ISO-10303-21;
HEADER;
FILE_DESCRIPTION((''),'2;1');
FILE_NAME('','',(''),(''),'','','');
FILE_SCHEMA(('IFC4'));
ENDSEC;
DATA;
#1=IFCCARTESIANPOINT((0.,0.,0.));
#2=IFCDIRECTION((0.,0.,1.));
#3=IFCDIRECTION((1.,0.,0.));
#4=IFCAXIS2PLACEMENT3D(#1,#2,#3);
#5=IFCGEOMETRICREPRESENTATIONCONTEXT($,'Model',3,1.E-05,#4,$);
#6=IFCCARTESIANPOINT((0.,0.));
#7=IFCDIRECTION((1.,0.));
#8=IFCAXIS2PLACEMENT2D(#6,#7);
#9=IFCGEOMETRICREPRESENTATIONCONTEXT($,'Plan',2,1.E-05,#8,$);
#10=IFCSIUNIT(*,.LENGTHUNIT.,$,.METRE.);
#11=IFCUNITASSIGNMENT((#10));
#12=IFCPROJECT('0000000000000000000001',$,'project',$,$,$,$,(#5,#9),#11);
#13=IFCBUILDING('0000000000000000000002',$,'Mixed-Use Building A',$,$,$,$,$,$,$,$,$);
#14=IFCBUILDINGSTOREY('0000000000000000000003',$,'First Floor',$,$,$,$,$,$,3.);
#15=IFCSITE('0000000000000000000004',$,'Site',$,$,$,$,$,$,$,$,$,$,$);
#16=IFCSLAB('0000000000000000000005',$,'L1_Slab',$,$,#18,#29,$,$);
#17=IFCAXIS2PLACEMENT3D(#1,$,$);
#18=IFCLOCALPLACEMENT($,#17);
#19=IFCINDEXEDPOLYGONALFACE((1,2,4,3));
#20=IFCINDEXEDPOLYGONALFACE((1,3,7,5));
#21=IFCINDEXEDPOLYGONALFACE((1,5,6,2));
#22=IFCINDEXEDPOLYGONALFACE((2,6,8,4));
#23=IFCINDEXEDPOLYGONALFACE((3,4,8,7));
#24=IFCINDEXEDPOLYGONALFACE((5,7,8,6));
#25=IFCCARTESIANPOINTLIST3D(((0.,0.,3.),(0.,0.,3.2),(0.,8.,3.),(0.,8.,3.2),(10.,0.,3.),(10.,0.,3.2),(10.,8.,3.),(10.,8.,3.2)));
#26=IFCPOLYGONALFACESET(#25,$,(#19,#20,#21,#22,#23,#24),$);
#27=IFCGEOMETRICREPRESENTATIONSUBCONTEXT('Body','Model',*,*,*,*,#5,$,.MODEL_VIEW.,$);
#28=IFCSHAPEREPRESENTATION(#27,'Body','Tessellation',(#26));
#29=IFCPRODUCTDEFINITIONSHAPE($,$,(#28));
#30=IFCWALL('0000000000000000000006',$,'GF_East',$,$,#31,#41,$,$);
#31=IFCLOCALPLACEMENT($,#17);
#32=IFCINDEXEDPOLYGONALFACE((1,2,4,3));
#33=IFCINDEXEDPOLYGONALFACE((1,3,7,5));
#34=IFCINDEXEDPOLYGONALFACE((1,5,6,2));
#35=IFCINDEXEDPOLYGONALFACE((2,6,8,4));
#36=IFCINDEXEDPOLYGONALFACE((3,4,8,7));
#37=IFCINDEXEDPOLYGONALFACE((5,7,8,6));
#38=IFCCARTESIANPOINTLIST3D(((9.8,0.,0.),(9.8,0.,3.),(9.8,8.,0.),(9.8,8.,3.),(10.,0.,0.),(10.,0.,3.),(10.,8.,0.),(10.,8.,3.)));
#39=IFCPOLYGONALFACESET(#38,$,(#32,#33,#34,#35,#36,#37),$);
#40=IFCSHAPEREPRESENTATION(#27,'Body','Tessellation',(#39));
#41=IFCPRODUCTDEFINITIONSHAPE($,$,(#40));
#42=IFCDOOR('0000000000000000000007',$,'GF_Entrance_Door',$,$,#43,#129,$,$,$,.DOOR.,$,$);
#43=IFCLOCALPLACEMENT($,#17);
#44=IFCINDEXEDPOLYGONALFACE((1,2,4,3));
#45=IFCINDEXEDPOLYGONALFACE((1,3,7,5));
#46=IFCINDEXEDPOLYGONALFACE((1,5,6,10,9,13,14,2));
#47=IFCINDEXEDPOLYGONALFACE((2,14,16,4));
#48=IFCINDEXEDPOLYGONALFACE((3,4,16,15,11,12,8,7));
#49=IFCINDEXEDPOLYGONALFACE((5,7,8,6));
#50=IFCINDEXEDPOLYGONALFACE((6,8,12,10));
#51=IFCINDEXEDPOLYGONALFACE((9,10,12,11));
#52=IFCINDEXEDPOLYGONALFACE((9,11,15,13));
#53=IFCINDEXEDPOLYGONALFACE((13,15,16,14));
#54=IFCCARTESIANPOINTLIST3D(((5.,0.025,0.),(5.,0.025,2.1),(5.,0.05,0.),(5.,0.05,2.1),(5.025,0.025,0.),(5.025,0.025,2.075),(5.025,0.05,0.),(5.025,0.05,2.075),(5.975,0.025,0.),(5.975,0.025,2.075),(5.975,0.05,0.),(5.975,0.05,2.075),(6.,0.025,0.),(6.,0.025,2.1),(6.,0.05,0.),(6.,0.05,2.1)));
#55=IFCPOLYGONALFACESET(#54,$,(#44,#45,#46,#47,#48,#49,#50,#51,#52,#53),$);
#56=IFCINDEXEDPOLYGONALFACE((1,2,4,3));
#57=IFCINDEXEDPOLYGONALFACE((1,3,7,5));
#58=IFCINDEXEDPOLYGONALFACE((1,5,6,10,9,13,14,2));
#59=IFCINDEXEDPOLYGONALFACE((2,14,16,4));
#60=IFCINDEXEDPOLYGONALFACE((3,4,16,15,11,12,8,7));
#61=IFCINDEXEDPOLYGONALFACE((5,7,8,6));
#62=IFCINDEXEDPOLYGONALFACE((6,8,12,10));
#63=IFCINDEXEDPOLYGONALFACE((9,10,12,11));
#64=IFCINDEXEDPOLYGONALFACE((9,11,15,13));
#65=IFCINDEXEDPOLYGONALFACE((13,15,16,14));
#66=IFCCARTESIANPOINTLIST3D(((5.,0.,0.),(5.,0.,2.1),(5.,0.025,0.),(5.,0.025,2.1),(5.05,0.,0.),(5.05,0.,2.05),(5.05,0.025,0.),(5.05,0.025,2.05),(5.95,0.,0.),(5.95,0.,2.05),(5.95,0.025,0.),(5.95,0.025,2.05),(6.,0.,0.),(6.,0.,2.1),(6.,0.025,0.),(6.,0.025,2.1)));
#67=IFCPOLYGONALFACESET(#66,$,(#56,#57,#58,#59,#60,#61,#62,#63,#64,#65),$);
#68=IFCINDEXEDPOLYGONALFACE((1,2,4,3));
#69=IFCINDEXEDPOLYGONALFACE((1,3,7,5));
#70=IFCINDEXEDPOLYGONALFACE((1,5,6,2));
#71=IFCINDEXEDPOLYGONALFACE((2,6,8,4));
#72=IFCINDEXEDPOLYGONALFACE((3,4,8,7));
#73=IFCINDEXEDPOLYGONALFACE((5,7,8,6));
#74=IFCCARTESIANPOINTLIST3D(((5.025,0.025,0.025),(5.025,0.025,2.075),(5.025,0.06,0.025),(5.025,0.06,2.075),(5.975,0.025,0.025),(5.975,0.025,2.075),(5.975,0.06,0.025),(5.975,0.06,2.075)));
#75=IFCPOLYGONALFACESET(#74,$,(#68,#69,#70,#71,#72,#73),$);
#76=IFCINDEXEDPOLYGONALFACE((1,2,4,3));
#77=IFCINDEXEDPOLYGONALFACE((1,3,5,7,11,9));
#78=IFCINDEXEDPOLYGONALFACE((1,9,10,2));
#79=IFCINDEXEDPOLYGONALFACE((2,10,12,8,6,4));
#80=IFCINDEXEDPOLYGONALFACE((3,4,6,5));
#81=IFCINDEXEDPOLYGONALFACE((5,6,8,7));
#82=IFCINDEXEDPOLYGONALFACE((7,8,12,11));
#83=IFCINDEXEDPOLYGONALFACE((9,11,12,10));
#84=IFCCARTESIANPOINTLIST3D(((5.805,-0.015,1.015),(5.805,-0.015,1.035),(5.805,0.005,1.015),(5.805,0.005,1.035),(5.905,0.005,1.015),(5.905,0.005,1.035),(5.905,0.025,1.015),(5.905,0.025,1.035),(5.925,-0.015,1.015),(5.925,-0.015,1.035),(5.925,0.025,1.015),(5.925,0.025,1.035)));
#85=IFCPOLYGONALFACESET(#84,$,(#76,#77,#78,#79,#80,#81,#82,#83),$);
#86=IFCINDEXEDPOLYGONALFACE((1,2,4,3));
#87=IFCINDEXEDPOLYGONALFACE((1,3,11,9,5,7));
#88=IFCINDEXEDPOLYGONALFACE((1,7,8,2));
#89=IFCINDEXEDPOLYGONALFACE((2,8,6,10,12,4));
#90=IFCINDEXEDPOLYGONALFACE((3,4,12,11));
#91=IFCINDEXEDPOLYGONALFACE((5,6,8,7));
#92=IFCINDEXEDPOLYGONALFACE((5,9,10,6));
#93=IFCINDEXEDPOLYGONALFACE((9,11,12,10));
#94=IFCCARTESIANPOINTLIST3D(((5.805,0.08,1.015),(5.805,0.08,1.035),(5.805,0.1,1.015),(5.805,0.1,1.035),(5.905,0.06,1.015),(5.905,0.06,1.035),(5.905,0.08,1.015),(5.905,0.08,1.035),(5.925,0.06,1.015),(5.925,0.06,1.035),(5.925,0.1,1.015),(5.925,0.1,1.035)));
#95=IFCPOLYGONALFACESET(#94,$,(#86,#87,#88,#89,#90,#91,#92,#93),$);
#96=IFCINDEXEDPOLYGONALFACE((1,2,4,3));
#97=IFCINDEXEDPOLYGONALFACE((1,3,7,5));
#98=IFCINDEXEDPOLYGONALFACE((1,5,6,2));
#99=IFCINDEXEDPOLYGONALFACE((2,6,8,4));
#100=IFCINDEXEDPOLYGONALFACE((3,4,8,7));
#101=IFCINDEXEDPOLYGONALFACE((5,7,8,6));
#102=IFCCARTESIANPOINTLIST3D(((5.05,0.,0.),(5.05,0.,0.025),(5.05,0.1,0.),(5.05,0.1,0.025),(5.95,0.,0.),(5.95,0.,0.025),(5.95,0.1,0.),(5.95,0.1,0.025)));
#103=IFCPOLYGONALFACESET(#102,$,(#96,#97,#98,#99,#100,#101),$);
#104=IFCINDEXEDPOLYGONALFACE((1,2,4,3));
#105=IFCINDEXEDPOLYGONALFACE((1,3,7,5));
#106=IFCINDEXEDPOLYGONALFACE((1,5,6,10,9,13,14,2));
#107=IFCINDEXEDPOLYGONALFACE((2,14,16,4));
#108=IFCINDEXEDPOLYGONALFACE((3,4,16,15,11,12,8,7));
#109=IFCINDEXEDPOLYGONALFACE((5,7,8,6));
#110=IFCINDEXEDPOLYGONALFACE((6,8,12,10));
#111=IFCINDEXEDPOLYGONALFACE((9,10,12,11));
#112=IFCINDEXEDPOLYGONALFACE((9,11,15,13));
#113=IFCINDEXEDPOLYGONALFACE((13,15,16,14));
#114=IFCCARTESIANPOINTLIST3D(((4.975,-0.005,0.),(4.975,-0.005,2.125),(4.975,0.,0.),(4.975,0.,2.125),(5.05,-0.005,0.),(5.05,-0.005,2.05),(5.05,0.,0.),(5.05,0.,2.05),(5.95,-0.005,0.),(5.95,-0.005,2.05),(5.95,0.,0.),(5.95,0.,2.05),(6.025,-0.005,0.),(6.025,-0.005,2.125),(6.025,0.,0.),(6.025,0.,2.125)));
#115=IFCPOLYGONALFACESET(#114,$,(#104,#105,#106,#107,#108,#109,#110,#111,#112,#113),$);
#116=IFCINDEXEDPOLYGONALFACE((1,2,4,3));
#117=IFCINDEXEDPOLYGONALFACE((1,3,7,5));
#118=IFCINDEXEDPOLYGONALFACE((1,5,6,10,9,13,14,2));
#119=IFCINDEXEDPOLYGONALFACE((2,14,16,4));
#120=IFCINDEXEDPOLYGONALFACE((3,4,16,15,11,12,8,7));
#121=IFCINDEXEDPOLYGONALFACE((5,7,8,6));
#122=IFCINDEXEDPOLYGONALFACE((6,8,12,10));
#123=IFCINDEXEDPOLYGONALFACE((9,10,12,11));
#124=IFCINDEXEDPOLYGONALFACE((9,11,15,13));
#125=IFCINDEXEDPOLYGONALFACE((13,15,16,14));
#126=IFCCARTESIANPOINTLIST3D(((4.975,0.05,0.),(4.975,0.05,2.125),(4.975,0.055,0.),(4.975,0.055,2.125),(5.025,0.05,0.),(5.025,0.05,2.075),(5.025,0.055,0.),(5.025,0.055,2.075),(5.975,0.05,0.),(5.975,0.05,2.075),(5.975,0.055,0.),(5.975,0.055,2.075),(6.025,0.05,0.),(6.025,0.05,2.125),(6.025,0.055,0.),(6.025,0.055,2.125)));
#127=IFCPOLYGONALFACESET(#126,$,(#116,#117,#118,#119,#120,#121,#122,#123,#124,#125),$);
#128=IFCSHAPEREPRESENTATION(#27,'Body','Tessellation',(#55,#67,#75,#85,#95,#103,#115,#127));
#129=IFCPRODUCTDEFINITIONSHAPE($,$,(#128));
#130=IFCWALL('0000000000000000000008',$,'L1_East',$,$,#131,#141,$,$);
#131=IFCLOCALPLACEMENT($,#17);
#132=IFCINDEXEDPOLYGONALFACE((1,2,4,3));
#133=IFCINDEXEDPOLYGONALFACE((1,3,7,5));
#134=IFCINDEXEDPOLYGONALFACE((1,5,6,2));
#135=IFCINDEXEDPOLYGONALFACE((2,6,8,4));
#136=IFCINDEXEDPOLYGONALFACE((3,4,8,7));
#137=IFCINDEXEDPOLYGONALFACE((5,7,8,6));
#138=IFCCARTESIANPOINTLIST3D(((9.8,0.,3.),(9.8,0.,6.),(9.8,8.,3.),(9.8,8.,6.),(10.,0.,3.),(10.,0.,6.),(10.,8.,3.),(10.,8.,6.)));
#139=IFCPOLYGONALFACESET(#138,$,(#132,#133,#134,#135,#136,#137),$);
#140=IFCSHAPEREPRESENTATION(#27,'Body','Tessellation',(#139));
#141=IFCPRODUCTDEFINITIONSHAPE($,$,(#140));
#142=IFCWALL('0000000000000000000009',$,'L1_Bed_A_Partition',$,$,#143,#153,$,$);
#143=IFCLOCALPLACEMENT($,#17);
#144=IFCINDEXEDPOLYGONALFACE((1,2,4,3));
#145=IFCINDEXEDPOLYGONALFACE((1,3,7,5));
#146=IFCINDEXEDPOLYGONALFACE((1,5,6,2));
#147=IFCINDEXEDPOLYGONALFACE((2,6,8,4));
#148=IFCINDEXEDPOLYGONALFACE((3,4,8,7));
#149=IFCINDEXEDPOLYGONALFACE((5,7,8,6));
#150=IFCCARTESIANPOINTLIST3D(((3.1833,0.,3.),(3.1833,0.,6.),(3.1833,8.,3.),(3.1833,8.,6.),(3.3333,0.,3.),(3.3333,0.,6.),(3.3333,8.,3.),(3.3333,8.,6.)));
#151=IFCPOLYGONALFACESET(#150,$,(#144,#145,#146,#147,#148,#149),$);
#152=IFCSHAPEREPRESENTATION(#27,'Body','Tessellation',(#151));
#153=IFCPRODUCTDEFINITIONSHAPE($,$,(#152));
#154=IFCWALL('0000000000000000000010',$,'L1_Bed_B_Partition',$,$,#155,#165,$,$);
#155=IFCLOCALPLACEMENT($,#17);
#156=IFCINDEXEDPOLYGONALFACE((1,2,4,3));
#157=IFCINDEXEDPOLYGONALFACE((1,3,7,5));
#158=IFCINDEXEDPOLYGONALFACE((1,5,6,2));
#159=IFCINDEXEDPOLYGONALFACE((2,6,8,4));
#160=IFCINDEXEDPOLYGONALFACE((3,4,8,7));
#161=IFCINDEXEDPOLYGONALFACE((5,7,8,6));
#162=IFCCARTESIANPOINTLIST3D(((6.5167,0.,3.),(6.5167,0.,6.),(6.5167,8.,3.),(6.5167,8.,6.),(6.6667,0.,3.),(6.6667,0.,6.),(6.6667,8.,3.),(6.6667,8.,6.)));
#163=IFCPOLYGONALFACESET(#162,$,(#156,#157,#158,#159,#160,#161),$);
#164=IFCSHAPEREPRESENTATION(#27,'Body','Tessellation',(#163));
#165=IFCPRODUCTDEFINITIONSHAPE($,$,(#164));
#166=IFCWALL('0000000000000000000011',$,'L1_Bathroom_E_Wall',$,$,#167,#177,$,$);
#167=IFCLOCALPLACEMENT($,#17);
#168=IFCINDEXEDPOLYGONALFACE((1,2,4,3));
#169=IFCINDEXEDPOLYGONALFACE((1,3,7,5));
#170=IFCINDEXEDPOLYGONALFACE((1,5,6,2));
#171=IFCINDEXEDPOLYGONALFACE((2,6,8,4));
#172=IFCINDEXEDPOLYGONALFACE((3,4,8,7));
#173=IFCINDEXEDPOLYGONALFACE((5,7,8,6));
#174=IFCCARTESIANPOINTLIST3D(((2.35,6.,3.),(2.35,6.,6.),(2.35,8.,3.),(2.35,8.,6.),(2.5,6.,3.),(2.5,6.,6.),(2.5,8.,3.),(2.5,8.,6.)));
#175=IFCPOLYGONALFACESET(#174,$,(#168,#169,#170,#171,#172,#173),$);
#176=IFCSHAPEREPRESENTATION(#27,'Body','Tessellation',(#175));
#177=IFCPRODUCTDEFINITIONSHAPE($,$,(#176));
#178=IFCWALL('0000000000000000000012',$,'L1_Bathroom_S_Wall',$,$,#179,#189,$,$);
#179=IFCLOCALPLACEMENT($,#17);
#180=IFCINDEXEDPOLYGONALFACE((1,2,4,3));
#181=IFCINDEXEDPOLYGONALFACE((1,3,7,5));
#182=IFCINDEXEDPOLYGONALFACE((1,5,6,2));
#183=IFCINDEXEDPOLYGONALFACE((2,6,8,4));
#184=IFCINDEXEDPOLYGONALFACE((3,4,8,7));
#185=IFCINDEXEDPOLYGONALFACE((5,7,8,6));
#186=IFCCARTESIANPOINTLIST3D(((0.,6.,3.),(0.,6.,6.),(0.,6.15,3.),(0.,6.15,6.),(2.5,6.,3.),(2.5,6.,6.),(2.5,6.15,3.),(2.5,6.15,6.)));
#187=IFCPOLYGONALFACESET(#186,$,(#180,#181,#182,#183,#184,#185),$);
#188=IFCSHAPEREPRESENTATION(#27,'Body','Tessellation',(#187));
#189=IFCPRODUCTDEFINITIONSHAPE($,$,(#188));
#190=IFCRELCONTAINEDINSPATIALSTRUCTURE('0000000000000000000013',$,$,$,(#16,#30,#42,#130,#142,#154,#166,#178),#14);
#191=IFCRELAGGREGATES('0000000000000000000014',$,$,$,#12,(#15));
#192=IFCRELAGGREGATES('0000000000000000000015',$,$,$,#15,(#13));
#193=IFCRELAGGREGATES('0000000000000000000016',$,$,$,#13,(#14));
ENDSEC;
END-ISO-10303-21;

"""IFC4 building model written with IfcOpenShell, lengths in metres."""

from ifc_helpers import new_model, si_unit, frame, origin_with_axes, origin_2d_with_axis, place, context, subcontext, project, spatial, line, indexed_curve, outline, extrude, element, save


model = new_model("IFC4")

# Units and contexts
model_context = context("Model", 3, precision=1e-05, world=origin_with_axes())
plan_context = context("Plan", 2, precision=1e-05, world=origin_2d_with_axis())
body_context = subcontext(model_context, "Body", "Model", "MODEL_VIEW")
ifc_project = project(units=[si_unit("LENGTHUNIT", "METRE")], contexts=[model_context, plan_context])

# Site, building, storey
site = spatial("IfcSite", under=ifc_project, Name="Site")
building = spatial("IfcBuilding", under=site, Name="Mixed-Use Building A")
storey = spatial("IfcBuildingStorey", under=building, Name="First Floor", Elevation=3.0)

# Slab
slab_placement = place(None, frame((0.0, 0.0, 3.0), z_axis=(0.0, 0.0, 1.0), x_axis=(1.0, 0.0, 0.0)))
element("IfcSlab", 1, at=slab_placement, inside=storey, Name="L1_Slab", context=body_context, shape_type="SweptSolid", body=[
    extrude(outline(indexed_curve([(0.0, 0.0), (10.0, 0.0), (10.0, 8.0), (0.0, 8.0)])), None, (0.0, 0.0, 1.0), 0.2),
])

# Wall
wall_1_placement = place(None, frame((10.0, 0.0, 0.0), z_axis=(0.0, 0.0, 1.0), x_axis=(0.0, 1.0, 0.0)))
element("IfcWall", 2, at=wall_1_placement, inside=storey, Name="GF_East", context=body_context, shape_type="SweptSolid", body=[
    extrude(outline(indexed_curve([(0.0, 0.0), (0.0, 0.2), (8.0, 0.2), (8.0, 0.0), (0.0, 0.0)], self_intersect=False)), origin_with_axes(), (0.0, 0.0, 1.0), 3.0),
])

# Door
door_placement = place(None, frame((5.0, 0.0, 0.0), z_axis=(0.0, 0.0, 1.0), x_axis=(1.0, 0.0, 0.0)))
element("IfcDoor", 3, at=door_placement, inside=storey, Name="GF_Entrance_Door", PredefinedType="DOOR", context=body_context, shape_type="SweptSolid", body=[
    extrude(outline(indexed_curve([(0.0, 0.0), (0.0, 2.1), (1.0, 2.1), (1.0, 0.0), (0.975, 0.0), (0.975, 2.075), (0.025, 2.075), (0.025, 0.0)], segments=[line(1, 2, 3, 4, 5, 6, 7, 8, 1)])), frame((0.0, 0.025, 0.0), z_axis=(0.0, -1.0, 0.0), x_axis=(1.0, 0.0, 0.0)), (0.0, 0.0, -1.0), 0.025),
    extrude(outline(indexed_curve([(0.0, 0.0), (0.0, 2.1), (1.0, 2.1), (1.0, 0.0), (0.95, 0.0), (0.95, 2.05), (0.05, 2.05), (0.05, 0.0)], segments=[line(1, 2, 3, 4, 5, 6, 7, 8, 1)])), frame((0.0, 0.0, 0.0), z_axis=(0.0, -1.0, 0.0), x_axis=(1.0, 0.0, 0.0)), (0.0, 0.0, -1.0), 0.025),
    extrude(outline(indexed_curve([(0.0, 0.0), (0.95, 0.0), (0.95, 0.035), (0.0, 0.035)], segments=[line(1, 2, 3, 4, 1)])), frame((0.025, 0.025, 0.025), z_axis=(0.0, 0.0, 1.0), x_axis=(1.0, 0.0, 0.0)), (0.0, 0.0, 1.0), 2.05),
    extrude(outline(indexed_curve([(0.0, 0.0), (0.0, -0.04), (-0.12, -0.04), (-0.12, -0.02), (-0.02, -0.02), (-0.02, 0.0)], segments=[line(1, 2, 3, 4, 5, 6, 1)])), frame((0.925, 0.025, 1.015), z_axis=(0.0, 0.0, 1.0), x_axis=(1.0, 0.0, 0.0)), (0.0, 0.0, 1.0), 0.02),
    extrude(outline(indexed_curve([(0.0, 0.0), (0.0, 0.04), (-0.12, 0.04), (-0.12, 0.02), (-0.02, 0.02), (-0.02, 0.0)], segments=[line(1, 2, 3, 4, 5, 6, 1)])), frame((0.925, 0.06, 1.015), z_axis=(0.0, 0.0, 1.0), x_axis=(1.0, 0.0, 0.0)), (0.0, 0.0, 1.0), 0.02),
    extrude(outline(indexed_curve([(0.0, 0.0), (0.9, 0.0), (0.9, 0.1), (0.0, 0.1)], segments=[line(1, 2, 3, 4, 1)])), frame((0.05, 0.0, 0.0), z_axis=(0.0, 0.0, 1.0), x_axis=(1.0, 0.0, 0.0)), (0.0, 0.0, 1.0), 0.025),
    extrude(outline(indexed_curve([(0.0, 0.0), (0.0, 2.125), (1.05, 2.125), (1.05, 0.0), (0.975, 0.0), (0.975, 2.05), (0.075, 2.05), (0.075, 0.0)], segments=[line(1, 2, 3, 4, 5, 6, 7, 8, 1)])), frame((-0.025, -0.005, 0.0), z_axis=(0.0, -1.0, 0.0), x_axis=(1.0, 0.0, 0.0)), (0.0, 0.0, -1.0), 0.005),
    extrude(outline(indexed_curve([(0.0, 0.0), (0.0, 2.125), (1.05, 2.125), (1.05, 0.0), (1.0, 0.0), (1.0, 2.075), (0.05, 2.075), (0.05, 0.0)], segments=[line(1, 2, 3, 4, 5, 6, 7, 8, 1)])), frame((-0.025, 0.05, 0.0), z_axis=(0.0, -1.0, 0.0), x_axis=(1.0, 0.0, 0.0)), (0.0, 0.0, -1.0), 0.005),
])

# Walls
wall_2_placement = place(None, frame((10.0, 0.0, 3.0), z_axis=(0.0, 0.0, 1.0), x_axis=(0.0, 1.0, 0.0)))
element("IfcWall", 4, at=wall_2_placement, inside=storey, Name="L1_East", context=body_context, shape_type="SweptSolid", body=[
    extrude(outline(indexed_curve([(0.0, 0.0), (0.0, 0.2), (8.0, 0.2), (8.0, 0.0), (0.0, 0.0)], self_intersect=False)), origin_with_axes(), (0.0, 0.0, 1.0), 3.0),
])
for number, where, z_axis, x_axis, name in (
    (5, (3.3333, 0.0, 3.0), (0.0, 0.0, 1.0), (0.0, 1.0, 0.0), "L1_Bed_A_Partition"),
    (6, (6.6667, 0.0, 3.0), (0.0, 0.0, 1.0), (0.0, 1.0, 0.0), "L1_Bed_B_Partition"),
):
    element("IfcWall", number, at=place(None, frame(where, z_axis=z_axis, x_axis=x_axis)), inside=storey, Name=name, context=body_context, shape_type="SweptSolid", body=[
        extrude(outline(indexed_curve([(0.0, 0.0), (0.0, 0.15), (8.0, 0.15), (8.0, 0.0), (0.0, 0.0)], self_intersect=False)), origin_with_axes(), (0.0, 0.0, 1.0), 3.0),
    ])
wall_3_placement = place(None, frame((2.5, 6.0, 3.0), z_axis=(0.0, 0.0, 1.0), x_axis=(0.0, 1.0, 0.0)))
element("IfcWall", 7, at=wall_3_placement, inside=storey, Name="L1_Bathroom_E_Wall", context=body_context, shape_type="SweptSolid", body=[
    extrude(outline(indexed_curve([(0.0, 0.0), (0.0, 0.15), (2.0, 0.15), (2.0, 0.0), (0.0, 0.0)], self_intersect=False)), origin_with_axes(), (0.0, 0.0, 1.0), 3.0),
])
wall_4_placement = place(None, frame((0.0, 6.0, 3.0), z_axis=(0.0, 0.0, 1.0), x_axis=(1.0, 0.0, 0.0)))
element("IfcWall", 8, at=wall_4_placement, inside=storey, Name="L1_Bathroom_S_Wall", context=body_context, shape_type="SweptSolid", body=[
    extrude(outline(indexed_curve([(0.0, 0.0), (0.0, 0.15), (2.5, 0.15), (2.5, 0.0), (0.0, 0.0)], self_intersect=False)), origin_with_axes(), (0.0, 0.0, 1.0), 3.0),
])

save(model, "model.ifc")
